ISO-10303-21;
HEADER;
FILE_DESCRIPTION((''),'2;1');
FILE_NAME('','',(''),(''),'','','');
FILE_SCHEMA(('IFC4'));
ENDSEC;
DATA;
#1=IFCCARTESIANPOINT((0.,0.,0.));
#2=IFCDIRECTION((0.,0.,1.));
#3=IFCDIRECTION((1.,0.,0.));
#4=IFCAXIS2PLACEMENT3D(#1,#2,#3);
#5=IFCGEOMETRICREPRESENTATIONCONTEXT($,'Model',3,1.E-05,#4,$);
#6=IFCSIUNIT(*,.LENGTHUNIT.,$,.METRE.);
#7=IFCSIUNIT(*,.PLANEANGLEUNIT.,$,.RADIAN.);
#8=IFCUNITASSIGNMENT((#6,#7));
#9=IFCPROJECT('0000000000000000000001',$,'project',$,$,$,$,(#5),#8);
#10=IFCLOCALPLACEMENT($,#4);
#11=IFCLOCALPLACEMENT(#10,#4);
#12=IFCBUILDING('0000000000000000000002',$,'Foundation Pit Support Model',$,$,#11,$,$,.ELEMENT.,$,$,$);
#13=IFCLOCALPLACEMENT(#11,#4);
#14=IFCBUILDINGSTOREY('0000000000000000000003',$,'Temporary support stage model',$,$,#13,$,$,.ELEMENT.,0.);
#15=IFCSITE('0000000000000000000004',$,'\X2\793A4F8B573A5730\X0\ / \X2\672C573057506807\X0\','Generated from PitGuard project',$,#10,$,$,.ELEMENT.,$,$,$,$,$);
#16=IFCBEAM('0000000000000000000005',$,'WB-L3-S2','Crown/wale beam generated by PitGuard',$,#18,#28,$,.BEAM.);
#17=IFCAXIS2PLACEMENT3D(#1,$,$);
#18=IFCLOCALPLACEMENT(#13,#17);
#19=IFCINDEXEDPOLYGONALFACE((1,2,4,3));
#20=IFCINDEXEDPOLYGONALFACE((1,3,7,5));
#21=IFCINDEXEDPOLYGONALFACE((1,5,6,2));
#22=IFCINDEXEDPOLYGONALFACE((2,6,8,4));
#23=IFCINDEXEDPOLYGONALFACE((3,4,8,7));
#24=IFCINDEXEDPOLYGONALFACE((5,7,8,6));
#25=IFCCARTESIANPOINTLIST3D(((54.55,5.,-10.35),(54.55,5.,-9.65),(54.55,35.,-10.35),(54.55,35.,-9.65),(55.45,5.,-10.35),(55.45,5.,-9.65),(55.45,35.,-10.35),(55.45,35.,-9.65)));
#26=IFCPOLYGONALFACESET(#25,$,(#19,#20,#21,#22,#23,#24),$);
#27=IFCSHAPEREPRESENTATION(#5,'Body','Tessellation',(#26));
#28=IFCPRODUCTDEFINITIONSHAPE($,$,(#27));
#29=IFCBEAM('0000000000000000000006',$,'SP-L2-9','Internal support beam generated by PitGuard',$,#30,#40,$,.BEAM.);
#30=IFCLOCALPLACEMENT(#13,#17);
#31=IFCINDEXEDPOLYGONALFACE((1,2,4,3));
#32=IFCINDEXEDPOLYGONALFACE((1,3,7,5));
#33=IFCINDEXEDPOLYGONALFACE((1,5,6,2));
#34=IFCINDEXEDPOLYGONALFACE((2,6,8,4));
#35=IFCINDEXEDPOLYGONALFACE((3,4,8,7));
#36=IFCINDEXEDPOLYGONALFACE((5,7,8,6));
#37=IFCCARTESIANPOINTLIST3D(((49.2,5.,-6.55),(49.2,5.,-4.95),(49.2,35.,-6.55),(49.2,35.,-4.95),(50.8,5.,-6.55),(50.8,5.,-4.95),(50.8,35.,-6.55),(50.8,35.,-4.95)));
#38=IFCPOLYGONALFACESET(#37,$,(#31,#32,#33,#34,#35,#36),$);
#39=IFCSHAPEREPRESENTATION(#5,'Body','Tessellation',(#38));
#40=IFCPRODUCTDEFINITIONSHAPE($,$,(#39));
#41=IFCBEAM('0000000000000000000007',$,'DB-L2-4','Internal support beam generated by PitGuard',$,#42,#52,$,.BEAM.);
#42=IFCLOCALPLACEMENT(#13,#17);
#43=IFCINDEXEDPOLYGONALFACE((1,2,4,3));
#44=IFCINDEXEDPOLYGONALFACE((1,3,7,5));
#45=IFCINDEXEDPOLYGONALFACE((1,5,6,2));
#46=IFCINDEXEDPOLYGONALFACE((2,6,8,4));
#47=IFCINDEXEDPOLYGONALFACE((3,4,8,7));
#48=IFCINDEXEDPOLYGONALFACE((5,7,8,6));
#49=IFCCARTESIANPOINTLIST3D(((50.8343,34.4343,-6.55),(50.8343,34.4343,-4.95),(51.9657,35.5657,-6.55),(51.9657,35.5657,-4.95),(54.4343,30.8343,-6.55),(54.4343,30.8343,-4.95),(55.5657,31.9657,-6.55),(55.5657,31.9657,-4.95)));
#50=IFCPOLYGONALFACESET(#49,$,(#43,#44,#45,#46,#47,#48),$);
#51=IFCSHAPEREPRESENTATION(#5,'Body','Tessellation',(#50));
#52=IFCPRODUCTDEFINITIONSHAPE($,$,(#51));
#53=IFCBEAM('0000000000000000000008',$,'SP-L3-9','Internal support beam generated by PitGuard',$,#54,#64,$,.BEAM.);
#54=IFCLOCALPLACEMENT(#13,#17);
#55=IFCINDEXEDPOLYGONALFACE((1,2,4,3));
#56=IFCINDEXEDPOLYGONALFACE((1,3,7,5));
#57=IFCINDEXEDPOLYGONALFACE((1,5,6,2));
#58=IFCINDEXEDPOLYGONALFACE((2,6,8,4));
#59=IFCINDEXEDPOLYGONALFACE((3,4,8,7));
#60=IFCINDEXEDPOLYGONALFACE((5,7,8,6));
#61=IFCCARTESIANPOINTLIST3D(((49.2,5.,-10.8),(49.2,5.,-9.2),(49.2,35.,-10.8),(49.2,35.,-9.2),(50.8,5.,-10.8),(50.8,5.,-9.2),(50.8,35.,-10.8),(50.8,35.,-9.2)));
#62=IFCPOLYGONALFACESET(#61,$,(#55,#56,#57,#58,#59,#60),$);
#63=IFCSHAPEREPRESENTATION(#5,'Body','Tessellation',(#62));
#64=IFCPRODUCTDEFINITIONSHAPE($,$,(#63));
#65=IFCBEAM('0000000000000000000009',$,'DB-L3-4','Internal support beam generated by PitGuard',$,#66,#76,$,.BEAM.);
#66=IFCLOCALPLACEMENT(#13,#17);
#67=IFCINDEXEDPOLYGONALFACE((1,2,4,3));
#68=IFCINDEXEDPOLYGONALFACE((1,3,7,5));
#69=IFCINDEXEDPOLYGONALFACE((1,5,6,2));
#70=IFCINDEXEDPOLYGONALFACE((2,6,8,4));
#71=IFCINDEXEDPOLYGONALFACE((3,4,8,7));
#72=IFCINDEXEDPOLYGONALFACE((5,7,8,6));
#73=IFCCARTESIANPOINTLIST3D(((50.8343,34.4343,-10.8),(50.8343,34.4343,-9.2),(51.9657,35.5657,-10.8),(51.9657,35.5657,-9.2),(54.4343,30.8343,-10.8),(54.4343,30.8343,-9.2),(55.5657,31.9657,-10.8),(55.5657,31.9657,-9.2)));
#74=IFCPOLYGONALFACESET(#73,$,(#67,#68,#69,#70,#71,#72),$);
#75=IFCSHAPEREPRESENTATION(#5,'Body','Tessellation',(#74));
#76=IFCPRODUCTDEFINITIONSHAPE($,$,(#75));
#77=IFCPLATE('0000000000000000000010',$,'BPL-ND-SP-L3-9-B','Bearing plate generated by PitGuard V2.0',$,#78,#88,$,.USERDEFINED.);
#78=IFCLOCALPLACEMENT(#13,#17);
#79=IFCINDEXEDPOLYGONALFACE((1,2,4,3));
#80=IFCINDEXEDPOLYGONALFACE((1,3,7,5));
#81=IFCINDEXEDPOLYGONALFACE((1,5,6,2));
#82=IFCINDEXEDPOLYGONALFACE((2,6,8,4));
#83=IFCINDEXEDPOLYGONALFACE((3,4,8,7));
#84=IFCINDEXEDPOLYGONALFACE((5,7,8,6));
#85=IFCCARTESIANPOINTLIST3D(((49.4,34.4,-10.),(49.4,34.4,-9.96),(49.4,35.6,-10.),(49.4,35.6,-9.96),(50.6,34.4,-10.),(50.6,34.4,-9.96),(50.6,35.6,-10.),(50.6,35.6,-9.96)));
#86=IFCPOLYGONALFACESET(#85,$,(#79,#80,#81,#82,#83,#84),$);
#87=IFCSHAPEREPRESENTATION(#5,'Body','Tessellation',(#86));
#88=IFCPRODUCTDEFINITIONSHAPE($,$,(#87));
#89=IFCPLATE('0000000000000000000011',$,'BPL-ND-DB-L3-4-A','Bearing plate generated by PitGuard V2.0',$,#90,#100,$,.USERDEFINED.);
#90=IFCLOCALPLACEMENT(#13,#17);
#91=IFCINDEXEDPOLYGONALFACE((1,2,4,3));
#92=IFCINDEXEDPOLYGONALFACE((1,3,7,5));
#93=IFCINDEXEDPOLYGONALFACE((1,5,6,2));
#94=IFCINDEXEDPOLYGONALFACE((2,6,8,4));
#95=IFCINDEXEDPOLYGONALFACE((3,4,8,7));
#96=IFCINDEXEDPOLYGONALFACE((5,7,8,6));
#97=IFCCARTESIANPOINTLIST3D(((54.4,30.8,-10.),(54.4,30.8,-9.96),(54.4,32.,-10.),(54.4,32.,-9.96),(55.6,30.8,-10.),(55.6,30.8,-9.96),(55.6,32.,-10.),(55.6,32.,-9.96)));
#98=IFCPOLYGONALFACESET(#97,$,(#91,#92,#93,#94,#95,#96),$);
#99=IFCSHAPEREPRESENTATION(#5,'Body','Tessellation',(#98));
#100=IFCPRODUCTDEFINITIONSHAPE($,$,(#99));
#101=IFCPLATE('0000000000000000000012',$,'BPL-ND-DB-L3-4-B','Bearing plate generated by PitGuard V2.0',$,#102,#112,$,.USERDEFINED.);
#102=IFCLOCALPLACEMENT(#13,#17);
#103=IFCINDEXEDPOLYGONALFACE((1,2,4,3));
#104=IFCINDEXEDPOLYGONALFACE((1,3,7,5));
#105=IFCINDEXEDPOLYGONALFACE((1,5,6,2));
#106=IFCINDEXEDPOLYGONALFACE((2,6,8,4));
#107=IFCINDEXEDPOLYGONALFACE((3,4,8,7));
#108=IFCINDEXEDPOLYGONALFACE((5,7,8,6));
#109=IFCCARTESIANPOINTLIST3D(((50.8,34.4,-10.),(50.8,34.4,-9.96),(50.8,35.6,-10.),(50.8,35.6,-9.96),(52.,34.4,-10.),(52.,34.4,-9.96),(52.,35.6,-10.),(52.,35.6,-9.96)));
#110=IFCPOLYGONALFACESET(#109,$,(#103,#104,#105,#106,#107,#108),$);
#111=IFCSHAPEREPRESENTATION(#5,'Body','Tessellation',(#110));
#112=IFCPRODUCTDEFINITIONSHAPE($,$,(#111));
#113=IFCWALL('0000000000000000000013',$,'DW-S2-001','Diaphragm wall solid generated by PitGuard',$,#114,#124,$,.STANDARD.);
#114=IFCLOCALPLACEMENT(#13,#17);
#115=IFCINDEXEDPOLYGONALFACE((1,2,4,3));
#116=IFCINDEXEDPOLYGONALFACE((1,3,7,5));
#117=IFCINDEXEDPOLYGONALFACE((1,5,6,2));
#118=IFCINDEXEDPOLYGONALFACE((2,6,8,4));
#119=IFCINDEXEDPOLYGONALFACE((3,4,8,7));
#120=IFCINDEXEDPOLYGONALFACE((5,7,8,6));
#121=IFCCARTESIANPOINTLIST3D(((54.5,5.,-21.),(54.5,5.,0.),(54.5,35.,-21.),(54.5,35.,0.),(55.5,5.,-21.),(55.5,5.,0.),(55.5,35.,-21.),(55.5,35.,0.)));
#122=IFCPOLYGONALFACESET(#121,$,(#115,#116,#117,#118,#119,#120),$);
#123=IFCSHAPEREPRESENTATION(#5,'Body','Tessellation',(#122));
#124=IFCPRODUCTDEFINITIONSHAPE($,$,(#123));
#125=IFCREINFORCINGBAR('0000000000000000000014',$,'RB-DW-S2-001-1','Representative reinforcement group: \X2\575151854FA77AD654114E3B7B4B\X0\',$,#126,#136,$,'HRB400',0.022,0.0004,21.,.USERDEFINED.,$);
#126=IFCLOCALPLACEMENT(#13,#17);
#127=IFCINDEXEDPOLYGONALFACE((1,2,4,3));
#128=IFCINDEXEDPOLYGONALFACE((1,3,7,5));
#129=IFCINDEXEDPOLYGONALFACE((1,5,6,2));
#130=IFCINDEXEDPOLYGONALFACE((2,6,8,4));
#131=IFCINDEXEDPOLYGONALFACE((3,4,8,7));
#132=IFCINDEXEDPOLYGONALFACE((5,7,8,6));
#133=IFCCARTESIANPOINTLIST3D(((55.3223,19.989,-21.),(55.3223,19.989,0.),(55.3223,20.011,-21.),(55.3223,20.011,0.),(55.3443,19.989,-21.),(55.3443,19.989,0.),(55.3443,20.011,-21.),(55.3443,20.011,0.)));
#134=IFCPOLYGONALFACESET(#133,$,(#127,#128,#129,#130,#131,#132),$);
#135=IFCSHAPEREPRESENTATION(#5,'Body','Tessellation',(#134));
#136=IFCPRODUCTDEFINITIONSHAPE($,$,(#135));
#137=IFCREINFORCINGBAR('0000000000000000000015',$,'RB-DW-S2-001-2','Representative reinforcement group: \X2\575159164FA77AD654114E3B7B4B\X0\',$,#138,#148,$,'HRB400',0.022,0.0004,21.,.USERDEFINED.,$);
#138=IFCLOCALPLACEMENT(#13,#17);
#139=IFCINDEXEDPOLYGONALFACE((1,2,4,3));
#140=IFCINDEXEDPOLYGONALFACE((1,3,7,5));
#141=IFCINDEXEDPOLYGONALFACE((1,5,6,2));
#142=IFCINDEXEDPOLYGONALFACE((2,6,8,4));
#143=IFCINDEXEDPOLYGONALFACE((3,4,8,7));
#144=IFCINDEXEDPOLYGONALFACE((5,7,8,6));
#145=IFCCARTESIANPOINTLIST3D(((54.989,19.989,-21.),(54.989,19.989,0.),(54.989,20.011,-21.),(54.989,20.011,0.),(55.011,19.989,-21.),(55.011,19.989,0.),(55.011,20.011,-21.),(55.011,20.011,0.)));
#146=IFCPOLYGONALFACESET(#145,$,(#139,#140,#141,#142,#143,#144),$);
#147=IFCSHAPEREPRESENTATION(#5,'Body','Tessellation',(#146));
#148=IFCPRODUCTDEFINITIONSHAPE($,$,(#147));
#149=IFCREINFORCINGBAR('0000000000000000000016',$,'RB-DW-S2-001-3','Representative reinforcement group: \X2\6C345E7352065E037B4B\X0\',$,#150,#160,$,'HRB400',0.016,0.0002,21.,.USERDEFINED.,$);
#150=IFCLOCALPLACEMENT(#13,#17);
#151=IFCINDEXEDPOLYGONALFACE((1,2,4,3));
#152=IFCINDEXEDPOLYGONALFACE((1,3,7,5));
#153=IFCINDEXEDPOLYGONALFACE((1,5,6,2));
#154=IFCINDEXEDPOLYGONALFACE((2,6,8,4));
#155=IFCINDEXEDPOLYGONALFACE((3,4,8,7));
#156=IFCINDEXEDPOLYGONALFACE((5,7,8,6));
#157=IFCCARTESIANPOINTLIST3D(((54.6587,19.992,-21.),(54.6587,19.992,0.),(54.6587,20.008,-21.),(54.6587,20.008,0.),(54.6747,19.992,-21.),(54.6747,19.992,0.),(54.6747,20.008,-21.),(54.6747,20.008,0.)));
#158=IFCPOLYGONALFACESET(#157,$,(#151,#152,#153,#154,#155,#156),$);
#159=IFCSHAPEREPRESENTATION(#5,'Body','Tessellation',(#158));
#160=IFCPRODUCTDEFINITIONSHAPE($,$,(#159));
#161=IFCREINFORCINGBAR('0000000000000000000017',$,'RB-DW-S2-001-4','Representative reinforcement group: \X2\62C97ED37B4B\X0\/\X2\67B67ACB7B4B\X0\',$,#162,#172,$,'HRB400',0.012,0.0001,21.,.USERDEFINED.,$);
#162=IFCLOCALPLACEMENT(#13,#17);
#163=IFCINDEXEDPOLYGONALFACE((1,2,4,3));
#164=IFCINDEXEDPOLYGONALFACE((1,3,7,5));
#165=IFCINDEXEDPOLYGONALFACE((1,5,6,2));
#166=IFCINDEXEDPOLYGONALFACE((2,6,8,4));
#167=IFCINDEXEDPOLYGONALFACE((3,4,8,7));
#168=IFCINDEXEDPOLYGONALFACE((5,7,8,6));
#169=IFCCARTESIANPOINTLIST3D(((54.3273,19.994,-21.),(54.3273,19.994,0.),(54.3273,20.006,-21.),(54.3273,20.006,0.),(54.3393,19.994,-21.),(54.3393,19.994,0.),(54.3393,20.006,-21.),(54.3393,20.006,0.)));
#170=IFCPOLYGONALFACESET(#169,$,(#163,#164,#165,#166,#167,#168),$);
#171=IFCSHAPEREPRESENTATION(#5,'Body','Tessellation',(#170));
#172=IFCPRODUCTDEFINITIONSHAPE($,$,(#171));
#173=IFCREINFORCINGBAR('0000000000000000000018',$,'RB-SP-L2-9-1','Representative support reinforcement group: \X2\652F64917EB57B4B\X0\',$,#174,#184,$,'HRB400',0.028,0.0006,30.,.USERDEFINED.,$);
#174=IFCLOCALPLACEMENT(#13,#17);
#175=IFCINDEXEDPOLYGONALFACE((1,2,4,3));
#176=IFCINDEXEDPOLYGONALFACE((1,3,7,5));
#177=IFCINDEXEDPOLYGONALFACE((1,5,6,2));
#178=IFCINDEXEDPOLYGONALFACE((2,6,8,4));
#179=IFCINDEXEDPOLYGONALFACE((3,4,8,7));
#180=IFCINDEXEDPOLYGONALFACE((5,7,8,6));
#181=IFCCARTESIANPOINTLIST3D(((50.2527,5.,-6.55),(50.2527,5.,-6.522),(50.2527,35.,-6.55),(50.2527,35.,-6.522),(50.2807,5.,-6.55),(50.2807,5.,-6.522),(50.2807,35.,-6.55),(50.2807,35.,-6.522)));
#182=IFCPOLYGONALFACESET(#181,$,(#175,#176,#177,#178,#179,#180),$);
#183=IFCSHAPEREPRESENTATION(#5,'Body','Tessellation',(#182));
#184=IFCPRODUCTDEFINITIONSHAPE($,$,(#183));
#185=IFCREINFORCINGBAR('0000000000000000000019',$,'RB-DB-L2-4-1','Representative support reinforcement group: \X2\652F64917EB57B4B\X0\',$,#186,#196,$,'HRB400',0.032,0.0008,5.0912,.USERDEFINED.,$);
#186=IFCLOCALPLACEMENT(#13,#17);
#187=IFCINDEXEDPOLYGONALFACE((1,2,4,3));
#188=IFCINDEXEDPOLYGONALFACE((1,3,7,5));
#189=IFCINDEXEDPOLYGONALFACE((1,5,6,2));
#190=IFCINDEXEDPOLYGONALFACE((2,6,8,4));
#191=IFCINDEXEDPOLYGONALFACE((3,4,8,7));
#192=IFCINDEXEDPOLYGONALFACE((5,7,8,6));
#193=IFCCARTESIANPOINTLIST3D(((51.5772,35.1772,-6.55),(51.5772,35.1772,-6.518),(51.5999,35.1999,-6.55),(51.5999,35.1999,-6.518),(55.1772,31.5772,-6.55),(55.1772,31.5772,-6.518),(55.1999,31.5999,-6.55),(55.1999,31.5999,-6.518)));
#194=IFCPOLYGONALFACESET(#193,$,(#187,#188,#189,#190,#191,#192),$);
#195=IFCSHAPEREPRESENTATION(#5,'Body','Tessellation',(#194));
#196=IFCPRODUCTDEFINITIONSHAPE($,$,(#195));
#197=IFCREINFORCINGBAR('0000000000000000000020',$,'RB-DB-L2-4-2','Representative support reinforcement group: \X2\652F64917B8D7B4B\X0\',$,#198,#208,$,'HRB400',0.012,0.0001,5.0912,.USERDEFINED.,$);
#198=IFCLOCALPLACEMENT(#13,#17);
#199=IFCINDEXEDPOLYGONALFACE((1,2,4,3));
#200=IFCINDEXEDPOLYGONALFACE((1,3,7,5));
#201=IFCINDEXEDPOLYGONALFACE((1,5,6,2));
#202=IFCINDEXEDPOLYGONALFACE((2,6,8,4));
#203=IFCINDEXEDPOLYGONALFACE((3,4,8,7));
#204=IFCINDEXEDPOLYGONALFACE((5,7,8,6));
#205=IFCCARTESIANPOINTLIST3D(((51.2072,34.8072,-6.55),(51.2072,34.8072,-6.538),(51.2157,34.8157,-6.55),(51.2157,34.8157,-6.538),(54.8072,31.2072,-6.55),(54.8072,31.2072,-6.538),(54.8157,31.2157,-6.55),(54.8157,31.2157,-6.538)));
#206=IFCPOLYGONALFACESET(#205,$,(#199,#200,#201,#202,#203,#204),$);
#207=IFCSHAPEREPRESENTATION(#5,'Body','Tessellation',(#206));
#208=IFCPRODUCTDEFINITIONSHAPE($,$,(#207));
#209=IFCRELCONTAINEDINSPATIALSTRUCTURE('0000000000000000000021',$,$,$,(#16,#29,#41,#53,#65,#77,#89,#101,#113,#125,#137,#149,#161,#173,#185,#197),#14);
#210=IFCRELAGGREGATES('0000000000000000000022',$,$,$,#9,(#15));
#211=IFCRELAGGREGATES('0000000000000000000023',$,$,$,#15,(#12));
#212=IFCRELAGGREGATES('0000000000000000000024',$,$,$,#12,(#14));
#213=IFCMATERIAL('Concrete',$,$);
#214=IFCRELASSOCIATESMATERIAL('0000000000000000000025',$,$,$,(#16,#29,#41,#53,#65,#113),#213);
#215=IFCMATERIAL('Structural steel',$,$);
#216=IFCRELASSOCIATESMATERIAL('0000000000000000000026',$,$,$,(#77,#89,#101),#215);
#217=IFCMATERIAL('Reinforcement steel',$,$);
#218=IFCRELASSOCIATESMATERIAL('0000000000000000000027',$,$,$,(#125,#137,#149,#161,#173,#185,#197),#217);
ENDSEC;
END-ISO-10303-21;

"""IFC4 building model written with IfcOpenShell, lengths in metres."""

from ifc_helpers import new_model, si_unit, frame, origin_with_axes, origin_2d, place, context, project, spatial, rectangle, extrude, material, element, save


model = new_model("IFC4")

# Units and contexts
model_context = context("Model", 3, precision=1e-05, world=origin_with_axes())
ifc_project = project(units=[si_unit("LENGTHUNIT", "METRE"), si_unit("PLANEANGLEUNIT", "RADIAN")], contexts=[model_context])

# Site, building, storey
site_placement = place(None, origin_with_axes())
site = spatial("IfcSite", under=ifc_project, at=site_placement, Name="示例场地 / 本地坐标", Description="Generated from PitGuard project", CompositionType="ELEMENT")
building_placement = place(site_placement, origin_with_axes())
building = spatial("IfcBuilding", under=site, at=building_placement, Name="Foundation Pit Support Model", CompositionType="ELEMENT")
storey_placement = place(building_placement, origin_with_axes())
storey = spatial("IfcBuildingStorey", under=building, at=storey_placement, Name="Temporary support stage model", CompositionType="ELEMENT", Elevation=0.0)

# Beams
ifc_material_1 = material(Name="Concrete")
beam_1_placement = place(storey_placement, frame((55.0, 20.0, -10.35), z_axis=(0.0, 0.0, 1.0), x_axis=(0.0, 1.0, 0.0)))
element("IfcBeam", 1, at=beam_1_placement, inside=storey, material=ifc_material_1, Name="WB-L3-S2", Description="Crown/wale beam generated by PitGuard", PredefinedType="BEAM", context=model_context, shape_type="SweptSolid", body=[
    extrude(rectangle(XDim=30.0, YDim=0.9, at=origin_2d()), origin_with_axes(), (0.0, 0.0, 1.0), 0.7),
])
beam_2_placement = place(storey_placement, frame((50.0, 20.0, -6.55), z_axis=(0.0, 0.0, 1.0), x_axis=(0.0, 1.0, 0.0)))
element("IfcBeam", 2, at=beam_2_placement, inside=storey, material=ifc_material_1, Name="SP-L2-9", Description="Internal support beam generated by PitGuard", PredefinedType="BEAM", context=model_context, shape_type="SweptSolid", body=[
    extrude(rectangle(XDim=30.0, YDim=1.6, at=origin_2d()), origin_with_axes(), (0.0, 0.0, 1.0), 1.6),
])
beam_3_placement = place(storey_placement, frame((53.2, 33.2, -6.55), z_axis=(0.0, 0.0, 1.0), x_axis=(-0.707107, 0.707107, 0.0)))
element("IfcBeam", 3, at=beam_3_placement, inside=storey, material=ifc_material_1, Name="DB-L2-4", Description="Internal support beam generated by PitGuard", PredefinedType="BEAM", context=model_context, shape_type="SweptSolid", body=[
    extrude(rectangle(XDim=5.0912, YDim=1.6, at=origin_2d()), origin_with_axes(), (0.0, 0.0, 1.0), 1.6),
])
beam_4_placement = place(storey_placement, frame((50.0, 20.0, -10.8), z_axis=(0.0, 0.0, 1.0), x_axis=(0.0, 1.0, 0.0)))
element("IfcBeam", 4, at=beam_4_placement, inside=storey, material=ifc_material_1, Name="SP-L3-9", Description="Internal support beam generated by PitGuard", PredefinedType="BEAM", context=model_context, shape_type="SweptSolid", body=[
    extrude(rectangle(XDim=30.0, YDim=1.6, at=origin_2d()), origin_with_axes(), (0.0, 0.0, 1.0), 1.6),
])
beam_5_placement = place(storey_placement, frame((53.2, 33.2, -10.8), z_axis=(0.0, 0.0, 1.0), x_axis=(-0.707107, 0.707107, 0.0)))
element("IfcBeam", 5, at=beam_5_placement, inside=storey, material=ifc_material_1, Name="DB-L3-4", Description="Internal support beam generated by PitGuard", PredefinedType="BEAM", context=model_context, shape_type="SweptSolid", body=[
    extrude(rectangle(XDim=5.0912, YDim=1.6, at=origin_2d()), origin_with_axes(), (0.0, 0.0, 1.0), 1.6),
])

# Plates
ifc_material_2 = material(Name="Structural steel")
for number, where, z_axis, x_axis, name in (
    (6, (50.0, 35.0, -10.0), (0.0, 0.0, 1.0), (1.0, 0.0, 0.0), "BPL-ND-SP-L3-9-B"),
    (7, (55.0, 31.4, -10.0), (0.0, 0.0, 1.0), (1.0, 0.0, 0.0), "BPL-ND-DB-L3-4-A"),
    (8, (51.4, 35.0, -10.0), (0.0, 0.0, 1.0), (1.0, 0.0, 0.0), "BPL-ND-DB-L3-4-B"),
):
    element("IfcPlate", number, at=place(storey_placement, frame(where, z_axis=z_axis, x_axis=x_axis)), inside=storey, material=ifc_material_2, Name=name, Description="Bearing plate generated by PitGuard V2.0", PredefinedType="USERDEFINED", context=model_context, shape_type="SweptSolid", body=[
        extrude(rectangle(XDim=1.2, YDim=1.2, at=origin_2d()), origin_with_axes(), (0.0, 0.0, 1.0), 0.04),
    ])

# Wall
wall_placement = place(storey_placement, frame((55.0, 20.0, -21.0), z_axis=(0.0, 0.0, 1.0), x_axis=(0.0, 1.0, 0.0)))
element("IfcWall", 9, at=wall_placement, inside=storey, material=ifc_material_1, Name="DW-S2-001", Description="Diaphragm wall solid generated by PitGuard", PredefinedType="STANDARD", context=model_context, shape_type="SweptSolid", body=[
    extrude(rectangle(XDim=30.0, YDim=1.0, at=origin_2d()), origin_with_axes(), (0.0, 0.0, 1.0), 21.0),
])

# Reinforcing bars
ifc_material_3 = material(Name="Reinforcement steel")
for number, where, z_axis, x_axis, name, description in (
    (10, (55.3333, 20.0, -21.0), (0.0, 0.0, 1.0), (1.0, 0.0, 0.0), "RB-DW-S2-001-1", "Representative reinforcement group: 坑内侧竖向主筋"),
    (11, (55.0, 20.0, -21.0), (0.0, 0.0, 1.0), (1.0, 0.0, 0.0), "RB-DW-S2-001-2", "Representative reinforcement group: 坑外侧竖向主筋"),
):
    element("IfcReinforcingBar", number, at=place(storey_placement, frame(where, z_axis=z_axis, x_axis=x_axis)), inside=storey, material=ifc_material_3, Name=name, Description=description, SteelGrade="HRB400", BarLength=21.0, CrossSectionArea=0.0004, NominalDiameter=0.022, PredefinedType="USERDEFINED", context=model_context, shape_type="SweptSolid", body=[
        extrude(rectangle(XDim=0.022, YDim=0.022, at=origin_2d()), origin_with_axes(), (0.0, 0.0, 1.0), 21.0),
    ])
reinforcing_bar_1_placement = place(storey_placement, frame((54.6667, 20.0, -21.0), z_axis=(0.0, 0.0, 1.0), x_axis=(1.0, 0.0, 0.0)))
element("IfcReinforcingBar", 12, at=reinforcing_bar_1_placement, inside=storey, material=ifc_material_3, Name="RB-DW-S2-001-3", Description="Representative reinforcement group: 水平分布筋", SteelGrade="HRB400", BarLength=21.0, CrossSectionArea=0.0002, NominalDiameter=0.016, PredefinedType="USERDEFINED", context=model_context, shape_type="SweptSolid", body=[
    extrude(rectangle(XDim=0.016, YDim=0.016, at=origin_2d()), origin_with_axes(), (0.0, 0.0, 1.0), 21.0),
])
reinforcing_bar_2_placement = place(storey_placement, frame((54.3333, 20.0, -21.0), z_axis=(0.0, 0.0, 1.0), x_axis=(1.0, 0.0, 0.0)))
element("IfcReinforcingBar", 13, at=reinforcing_bar_2_placement, inside=storey, material=ifc_material_3, Name="RB-DW-S2-001-4", Description="Representative reinforcement group: 拉结筋/架立筋", SteelGrade="HRB400", BarLength=21.0, CrossSectionArea=0.0001, NominalDiameter=0.012, PredefinedType="USERDEFINED", context=model_context, shape_type="SweptSolid", body=[
    extrude(rectangle(XDim=0.012, YDim=0.012, at=origin_2d()), origin_with_axes(), (0.0, 0.0, 1.0), 21.0),
])
reinforcing_bar_3_placement = place(storey_placement, frame((50.2667, 20.0, -6.55), z_axis=(0.0, 0.0, 1.0), x_axis=(0.0, 1.0, 0.0)))
element("IfcReinforcingBar", 14, at=reinforcing_bar_3_placement, inside=storey, material=ifc_material_3, Name="RB-SP-L2-9-1", Description="Representative support reinforcement group: 支撑纵筋", SteelGrade="HRB400", BarLength=30.0, CrossSectionArea=0.0006, NominalDiameter=0.028, PredefinedType="USERDEFINED", context=model_context, shape_type="SweptSolid", body=[
    extrude(rectangle(XDim=30.0, YDim=0.028, at=origin_2d()), origin_with_axes(), (0.0, 0.0, 1.0), 0.028),
])
reinforcing_bar_4_placement = place(storey_placement, frame((53.3886, 33.3886, -6.55), z_axis=(0.0, 0.0, 1.0), x_axis=(-0.707107, 0.707107, 0.0)))
element("IfcReinforcingBar", 15, at=reinforcing_bar_4_placement, inside=storey, material=ifc_material_3, Name="RB-DB-L2-4-1", Description="Representative support reinforcement group: 支撑纵筋", SteelGrade="HRB400", BarLength=5.0912, CrossSectionArea=0.0008, NominalDiameter=0.032, PredefinedType="USERDEFINED", context=model_context, shape_type="SweptSolid", body=[
    extrude(rectangle(XDim=5.0912, YDim=0.032, at=origin_2d()), origin_with_axes(), (0.0, 0.0, 1.0), 0.032),
])
reinforcing_bar_5_placement = place(storey_placement, frame((53.0114, 33.0114, -6.55), z_axis=(0.0, 0.0, 1.0), x_axis=(-0.707107, 0.707107, 0.0)))
element("IfcReinforcingBar", 16, at=reinforcing_bar_5_placement, inside=storey, material=ifc_material_3, Name="RB-DB-L2-4-2", Description="Representative support reinforcement group: 支撑箍筋", SteelGrade="HRB400", BarLength=5.0912, CrossSectionArea=0.0001, NominalDiameter=0.012, PredefinedType="USERDEFINED", context=model_context, shape_type="SweptSolid", body=[
    extrude(rectangle(XDim=5.0912, YDim=0.012, at=origin_2d()), origin_with_axes(), (0.0, 0.0, 1.0), 0.012),
])

save(model, "model.ifc")
